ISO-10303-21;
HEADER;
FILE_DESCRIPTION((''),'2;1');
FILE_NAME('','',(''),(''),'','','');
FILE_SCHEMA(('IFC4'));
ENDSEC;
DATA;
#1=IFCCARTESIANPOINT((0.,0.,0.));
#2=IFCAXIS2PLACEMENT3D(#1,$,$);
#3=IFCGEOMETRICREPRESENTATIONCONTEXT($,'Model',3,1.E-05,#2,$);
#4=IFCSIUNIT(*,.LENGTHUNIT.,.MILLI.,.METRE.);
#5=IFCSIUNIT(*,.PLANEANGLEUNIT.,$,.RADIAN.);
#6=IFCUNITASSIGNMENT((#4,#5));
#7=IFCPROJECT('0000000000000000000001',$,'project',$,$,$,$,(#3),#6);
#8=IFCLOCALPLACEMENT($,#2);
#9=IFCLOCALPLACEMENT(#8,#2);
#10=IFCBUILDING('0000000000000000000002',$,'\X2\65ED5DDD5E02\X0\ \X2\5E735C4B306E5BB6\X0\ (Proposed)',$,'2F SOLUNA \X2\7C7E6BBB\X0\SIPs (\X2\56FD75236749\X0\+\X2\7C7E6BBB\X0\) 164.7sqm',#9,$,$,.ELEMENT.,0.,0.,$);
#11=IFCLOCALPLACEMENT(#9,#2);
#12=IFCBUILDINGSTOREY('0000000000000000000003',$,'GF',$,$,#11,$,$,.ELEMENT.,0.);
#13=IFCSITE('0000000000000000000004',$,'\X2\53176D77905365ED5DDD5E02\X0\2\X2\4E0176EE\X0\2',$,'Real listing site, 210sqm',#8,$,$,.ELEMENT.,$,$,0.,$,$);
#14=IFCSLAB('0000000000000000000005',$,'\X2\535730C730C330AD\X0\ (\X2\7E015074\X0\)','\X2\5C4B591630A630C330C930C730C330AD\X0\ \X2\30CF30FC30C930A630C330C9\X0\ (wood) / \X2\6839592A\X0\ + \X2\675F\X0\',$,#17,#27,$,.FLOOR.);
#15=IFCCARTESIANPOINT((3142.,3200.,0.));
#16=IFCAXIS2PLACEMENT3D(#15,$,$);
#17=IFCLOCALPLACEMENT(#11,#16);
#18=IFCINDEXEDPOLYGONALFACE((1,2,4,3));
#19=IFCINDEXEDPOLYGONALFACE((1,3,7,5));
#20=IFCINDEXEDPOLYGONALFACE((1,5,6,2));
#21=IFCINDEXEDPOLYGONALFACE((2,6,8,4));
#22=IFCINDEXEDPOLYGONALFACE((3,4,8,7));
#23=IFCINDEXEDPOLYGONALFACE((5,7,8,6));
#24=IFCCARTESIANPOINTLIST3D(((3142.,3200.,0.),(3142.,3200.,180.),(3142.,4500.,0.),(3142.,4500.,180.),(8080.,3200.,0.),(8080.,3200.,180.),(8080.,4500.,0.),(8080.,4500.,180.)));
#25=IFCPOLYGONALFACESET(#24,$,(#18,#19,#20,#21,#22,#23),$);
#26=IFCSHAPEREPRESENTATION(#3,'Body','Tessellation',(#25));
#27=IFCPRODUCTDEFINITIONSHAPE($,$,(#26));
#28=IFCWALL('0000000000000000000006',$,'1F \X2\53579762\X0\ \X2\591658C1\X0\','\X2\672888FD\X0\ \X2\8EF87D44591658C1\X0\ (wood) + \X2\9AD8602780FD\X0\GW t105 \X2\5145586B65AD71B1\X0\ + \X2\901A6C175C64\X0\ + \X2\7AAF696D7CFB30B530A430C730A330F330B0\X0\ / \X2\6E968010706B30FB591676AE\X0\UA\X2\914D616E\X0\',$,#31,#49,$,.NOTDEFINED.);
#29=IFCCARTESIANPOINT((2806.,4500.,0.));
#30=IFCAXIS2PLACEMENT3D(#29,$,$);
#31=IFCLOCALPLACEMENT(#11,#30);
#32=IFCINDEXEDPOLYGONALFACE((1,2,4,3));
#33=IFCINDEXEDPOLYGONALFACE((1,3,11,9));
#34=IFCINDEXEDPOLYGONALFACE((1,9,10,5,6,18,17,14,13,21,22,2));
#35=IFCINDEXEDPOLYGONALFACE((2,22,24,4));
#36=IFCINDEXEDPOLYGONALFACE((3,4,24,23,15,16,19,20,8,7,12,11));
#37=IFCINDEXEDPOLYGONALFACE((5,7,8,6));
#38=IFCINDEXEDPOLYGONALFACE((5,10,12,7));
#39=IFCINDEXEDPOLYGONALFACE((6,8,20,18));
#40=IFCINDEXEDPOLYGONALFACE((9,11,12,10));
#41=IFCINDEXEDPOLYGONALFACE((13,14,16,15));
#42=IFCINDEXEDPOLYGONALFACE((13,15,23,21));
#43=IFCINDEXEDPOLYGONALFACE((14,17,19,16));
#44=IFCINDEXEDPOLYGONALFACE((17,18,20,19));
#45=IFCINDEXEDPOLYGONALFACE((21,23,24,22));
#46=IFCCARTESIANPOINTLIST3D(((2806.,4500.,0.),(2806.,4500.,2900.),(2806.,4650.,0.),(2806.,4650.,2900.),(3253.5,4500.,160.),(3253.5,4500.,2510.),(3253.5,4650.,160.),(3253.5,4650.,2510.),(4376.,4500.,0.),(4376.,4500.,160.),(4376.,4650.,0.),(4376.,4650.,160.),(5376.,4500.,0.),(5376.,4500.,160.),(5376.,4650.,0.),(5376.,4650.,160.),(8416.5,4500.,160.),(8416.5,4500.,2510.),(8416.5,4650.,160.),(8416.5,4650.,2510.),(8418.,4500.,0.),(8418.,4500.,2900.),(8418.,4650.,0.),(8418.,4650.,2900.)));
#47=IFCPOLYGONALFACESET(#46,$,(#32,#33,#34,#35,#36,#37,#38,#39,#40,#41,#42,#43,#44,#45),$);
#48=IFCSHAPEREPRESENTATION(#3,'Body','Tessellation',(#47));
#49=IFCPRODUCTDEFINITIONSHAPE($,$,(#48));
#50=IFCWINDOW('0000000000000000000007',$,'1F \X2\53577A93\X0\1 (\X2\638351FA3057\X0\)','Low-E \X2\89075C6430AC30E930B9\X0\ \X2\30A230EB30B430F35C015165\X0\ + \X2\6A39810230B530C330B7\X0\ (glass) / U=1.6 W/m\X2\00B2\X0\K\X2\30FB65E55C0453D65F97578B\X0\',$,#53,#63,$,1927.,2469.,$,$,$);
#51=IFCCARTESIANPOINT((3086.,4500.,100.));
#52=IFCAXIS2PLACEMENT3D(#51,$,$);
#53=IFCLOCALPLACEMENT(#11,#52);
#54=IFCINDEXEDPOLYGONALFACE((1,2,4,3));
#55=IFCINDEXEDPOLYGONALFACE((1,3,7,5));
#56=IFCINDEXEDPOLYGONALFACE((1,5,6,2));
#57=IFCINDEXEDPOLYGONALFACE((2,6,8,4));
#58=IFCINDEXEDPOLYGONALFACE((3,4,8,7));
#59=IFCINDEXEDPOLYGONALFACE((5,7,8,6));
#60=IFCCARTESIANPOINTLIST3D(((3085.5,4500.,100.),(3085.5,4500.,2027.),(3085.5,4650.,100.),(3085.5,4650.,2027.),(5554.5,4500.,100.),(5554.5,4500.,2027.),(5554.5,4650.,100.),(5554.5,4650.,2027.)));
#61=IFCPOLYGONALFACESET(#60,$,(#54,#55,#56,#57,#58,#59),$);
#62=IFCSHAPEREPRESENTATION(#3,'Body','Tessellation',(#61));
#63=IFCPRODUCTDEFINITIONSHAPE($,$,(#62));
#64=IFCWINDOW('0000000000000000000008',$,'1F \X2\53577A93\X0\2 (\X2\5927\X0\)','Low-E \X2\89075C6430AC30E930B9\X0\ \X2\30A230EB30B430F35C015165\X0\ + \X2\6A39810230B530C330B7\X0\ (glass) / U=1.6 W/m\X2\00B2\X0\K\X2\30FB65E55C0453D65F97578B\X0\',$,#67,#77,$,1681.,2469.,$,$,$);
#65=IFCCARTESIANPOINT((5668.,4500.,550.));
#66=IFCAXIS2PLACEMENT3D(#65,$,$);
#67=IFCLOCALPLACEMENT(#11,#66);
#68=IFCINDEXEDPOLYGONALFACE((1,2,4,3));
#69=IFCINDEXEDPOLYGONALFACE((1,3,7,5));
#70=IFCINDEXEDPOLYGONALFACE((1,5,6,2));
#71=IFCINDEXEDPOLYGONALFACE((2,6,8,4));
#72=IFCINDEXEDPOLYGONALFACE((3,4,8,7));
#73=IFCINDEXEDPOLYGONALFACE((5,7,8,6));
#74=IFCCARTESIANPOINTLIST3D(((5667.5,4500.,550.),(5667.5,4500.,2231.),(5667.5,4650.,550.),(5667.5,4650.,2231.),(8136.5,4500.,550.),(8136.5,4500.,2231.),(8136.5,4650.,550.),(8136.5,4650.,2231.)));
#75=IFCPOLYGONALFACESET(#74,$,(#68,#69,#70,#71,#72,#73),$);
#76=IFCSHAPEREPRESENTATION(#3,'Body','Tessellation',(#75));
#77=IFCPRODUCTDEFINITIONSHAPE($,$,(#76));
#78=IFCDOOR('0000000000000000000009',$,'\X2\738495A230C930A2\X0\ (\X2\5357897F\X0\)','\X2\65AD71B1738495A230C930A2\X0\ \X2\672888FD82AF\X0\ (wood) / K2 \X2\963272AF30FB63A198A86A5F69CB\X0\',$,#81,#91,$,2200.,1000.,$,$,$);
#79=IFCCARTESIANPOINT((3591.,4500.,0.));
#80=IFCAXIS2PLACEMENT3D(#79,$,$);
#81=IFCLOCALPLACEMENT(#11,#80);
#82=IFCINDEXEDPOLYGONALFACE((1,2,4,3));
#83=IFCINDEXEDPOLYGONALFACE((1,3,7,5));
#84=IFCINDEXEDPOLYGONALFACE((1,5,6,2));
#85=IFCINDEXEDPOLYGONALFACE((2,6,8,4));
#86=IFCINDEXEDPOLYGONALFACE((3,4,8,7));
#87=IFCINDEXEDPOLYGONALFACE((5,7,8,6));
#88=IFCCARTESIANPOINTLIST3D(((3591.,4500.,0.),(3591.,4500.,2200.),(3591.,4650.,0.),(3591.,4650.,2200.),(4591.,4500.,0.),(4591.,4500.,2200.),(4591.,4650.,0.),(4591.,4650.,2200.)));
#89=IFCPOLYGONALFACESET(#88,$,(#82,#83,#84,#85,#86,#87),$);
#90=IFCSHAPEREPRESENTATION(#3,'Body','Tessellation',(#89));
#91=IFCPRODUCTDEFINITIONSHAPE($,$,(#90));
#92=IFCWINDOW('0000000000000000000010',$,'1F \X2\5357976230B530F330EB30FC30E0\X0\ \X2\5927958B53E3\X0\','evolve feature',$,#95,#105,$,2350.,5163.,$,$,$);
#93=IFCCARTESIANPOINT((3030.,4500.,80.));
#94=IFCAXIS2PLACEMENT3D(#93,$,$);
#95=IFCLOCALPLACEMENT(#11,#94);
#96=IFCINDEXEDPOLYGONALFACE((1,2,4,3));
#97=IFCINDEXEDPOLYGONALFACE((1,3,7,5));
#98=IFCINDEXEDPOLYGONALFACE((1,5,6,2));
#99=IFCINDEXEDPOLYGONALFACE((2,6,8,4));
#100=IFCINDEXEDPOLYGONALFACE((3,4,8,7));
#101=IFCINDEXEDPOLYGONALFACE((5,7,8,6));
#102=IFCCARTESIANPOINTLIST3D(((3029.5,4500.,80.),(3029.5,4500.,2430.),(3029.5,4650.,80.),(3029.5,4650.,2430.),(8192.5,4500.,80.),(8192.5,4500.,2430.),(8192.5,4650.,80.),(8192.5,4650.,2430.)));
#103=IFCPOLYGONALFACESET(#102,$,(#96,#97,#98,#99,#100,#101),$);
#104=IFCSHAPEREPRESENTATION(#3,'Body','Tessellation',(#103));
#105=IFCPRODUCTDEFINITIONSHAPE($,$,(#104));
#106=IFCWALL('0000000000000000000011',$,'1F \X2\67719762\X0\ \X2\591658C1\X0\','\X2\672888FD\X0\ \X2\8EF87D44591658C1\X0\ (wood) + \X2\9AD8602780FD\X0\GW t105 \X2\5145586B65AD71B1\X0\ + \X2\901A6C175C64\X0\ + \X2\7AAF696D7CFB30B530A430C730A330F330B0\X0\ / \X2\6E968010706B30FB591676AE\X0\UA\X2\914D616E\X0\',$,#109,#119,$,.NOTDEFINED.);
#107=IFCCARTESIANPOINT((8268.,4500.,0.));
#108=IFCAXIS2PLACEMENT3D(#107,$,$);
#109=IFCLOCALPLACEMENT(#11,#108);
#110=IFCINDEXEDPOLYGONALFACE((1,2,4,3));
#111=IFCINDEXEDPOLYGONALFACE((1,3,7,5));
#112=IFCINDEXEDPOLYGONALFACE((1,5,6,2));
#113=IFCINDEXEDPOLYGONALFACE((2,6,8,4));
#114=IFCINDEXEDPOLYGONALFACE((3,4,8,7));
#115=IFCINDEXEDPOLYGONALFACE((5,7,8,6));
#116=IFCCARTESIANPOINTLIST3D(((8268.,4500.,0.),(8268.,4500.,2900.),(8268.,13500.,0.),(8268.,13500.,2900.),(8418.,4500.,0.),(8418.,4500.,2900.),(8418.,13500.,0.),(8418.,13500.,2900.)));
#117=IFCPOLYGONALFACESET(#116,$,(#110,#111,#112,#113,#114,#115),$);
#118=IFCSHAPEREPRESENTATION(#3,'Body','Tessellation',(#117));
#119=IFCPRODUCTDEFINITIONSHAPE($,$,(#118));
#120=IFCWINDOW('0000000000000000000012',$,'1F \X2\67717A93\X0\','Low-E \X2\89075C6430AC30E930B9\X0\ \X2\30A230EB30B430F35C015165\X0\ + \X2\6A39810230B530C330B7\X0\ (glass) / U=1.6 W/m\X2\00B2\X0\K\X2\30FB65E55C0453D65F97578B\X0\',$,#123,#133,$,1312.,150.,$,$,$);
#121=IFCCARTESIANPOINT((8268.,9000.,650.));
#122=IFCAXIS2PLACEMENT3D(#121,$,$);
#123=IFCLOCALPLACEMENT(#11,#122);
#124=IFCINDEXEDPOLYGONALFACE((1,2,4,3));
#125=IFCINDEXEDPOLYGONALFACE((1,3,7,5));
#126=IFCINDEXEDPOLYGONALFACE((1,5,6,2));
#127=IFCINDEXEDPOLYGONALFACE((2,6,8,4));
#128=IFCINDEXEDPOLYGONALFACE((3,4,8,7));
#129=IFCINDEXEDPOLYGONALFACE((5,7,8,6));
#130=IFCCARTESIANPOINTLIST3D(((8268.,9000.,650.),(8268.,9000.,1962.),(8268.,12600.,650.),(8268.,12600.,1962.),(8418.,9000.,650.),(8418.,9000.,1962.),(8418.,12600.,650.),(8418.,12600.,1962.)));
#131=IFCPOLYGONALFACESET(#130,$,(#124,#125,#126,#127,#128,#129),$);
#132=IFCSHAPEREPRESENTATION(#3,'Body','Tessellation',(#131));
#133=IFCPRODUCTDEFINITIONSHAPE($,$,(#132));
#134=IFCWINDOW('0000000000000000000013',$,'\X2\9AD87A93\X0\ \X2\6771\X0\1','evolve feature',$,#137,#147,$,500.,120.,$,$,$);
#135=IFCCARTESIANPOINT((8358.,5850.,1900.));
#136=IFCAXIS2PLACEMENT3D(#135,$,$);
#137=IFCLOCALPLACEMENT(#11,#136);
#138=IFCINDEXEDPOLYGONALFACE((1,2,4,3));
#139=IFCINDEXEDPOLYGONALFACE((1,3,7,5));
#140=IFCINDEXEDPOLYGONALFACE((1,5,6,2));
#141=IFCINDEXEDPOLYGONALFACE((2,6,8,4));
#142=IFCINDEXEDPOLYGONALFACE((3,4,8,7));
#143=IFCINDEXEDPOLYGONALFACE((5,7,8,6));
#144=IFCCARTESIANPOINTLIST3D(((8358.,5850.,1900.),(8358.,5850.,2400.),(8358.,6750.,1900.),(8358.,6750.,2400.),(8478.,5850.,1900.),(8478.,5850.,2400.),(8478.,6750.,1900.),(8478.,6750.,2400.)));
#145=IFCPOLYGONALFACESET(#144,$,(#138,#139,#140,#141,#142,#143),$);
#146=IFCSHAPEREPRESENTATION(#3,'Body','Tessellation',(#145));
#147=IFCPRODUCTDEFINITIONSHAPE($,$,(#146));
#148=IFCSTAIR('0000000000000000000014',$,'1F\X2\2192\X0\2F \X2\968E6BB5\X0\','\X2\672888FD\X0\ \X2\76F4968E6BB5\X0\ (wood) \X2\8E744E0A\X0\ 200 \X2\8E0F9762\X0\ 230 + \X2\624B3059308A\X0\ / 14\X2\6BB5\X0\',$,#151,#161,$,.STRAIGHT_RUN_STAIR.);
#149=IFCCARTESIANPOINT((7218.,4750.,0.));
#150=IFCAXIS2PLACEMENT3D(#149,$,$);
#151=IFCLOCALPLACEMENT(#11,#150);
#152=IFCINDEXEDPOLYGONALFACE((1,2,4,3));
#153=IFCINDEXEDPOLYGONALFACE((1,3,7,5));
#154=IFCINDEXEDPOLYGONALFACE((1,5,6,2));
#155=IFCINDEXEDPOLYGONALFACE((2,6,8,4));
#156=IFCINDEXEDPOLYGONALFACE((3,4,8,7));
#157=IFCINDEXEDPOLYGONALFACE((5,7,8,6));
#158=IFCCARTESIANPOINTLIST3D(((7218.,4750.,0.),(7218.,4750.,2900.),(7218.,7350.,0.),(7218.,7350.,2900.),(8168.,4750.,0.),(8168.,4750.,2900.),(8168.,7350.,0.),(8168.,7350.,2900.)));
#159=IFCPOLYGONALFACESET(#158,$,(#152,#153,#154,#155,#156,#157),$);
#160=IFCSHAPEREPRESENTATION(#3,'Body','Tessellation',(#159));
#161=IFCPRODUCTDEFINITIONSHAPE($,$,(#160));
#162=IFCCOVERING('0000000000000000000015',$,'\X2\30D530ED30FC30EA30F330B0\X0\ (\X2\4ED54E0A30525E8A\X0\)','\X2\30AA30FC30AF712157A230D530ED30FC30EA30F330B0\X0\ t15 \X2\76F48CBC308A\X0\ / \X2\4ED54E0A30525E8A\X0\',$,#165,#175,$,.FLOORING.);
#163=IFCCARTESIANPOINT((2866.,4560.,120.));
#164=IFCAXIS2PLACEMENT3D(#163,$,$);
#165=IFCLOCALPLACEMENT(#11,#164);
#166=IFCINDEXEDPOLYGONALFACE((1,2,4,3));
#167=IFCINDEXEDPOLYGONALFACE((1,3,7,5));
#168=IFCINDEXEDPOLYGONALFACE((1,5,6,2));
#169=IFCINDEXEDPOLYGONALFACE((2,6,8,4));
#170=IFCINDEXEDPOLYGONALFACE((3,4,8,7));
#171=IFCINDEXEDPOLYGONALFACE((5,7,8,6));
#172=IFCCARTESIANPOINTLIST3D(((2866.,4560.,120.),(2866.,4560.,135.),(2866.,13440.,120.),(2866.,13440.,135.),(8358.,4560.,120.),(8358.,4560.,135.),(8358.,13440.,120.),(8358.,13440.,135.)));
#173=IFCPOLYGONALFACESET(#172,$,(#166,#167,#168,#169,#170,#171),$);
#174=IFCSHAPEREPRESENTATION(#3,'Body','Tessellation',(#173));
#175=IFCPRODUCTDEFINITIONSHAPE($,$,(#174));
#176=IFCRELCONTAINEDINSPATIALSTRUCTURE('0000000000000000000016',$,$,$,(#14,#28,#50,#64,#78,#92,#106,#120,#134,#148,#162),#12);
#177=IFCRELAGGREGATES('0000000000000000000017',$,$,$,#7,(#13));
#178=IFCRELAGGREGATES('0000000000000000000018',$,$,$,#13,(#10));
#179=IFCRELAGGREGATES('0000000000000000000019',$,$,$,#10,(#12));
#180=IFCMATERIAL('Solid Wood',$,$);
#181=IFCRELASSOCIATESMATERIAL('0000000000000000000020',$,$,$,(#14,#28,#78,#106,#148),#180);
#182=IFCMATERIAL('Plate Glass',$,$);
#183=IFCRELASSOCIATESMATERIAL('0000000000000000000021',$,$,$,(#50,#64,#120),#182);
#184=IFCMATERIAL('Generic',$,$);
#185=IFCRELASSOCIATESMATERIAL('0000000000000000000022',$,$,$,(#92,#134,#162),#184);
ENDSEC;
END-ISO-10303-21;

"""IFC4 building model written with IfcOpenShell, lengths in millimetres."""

from ifc_helpers import new_model, si_unit, frame, frame_2d, origin, place, context, project, spatial, rectangle, extrude, material, element, fill, save


model = new_model("IFC4")

# Units and contexts
model_context = context("Model", 3, precision=1e-05, world=origin())
ifc_project = project(units=[si_unit("LENGTHUNIT", "METRE", prefix="MILLI"), si_unit("PLANEANGLEUNIT", "RADIAN")], contexts=[model_context])

# Site, building, storey
site_placement = place(None, origin())
site = spatial("IfcSite", under=ifc_project, at=site_placement, Name="北海道旭川市2丁目2", ObjectType="Real listing site, 210sqm", CompositionType="ELEMENT", RefElevation=0.0)
building_placement = place(site_placement, origin())
building = spatial("IfcBuilding", under=site, at=building_placement, Name="旭川市 平屋の家 (Proposed)", ObjectType="2F SOLUNA 籾殻SIPs (国産杉+籾殻) 164.7sqm", CompositionType="ELEMENT", ElevationOfRefHeight=0.0, ElevationOfTerrain=0.0)
storey_placement = place(building_placement, origin())
storey = spatial("IfcBuildingStorey", under=building, at=storey_placement, Name="GF", CompositionType="ELEMENT", Elevation=0.0)

# Slab
ifc_material_1 = material(Name="Solid Wood")
slab_1_placement = place(storey_placement, frame((3142.0, 3200.0, 0.0)))
element("IfcSlab", 1, at=slab_1_placement, inside=storey, material=ifc_material_1, Name="南デッキ (縁側)", Description="屋外ウッドデッキ ハードウッド (wood) / 根太 + 束", PredefinedType="FLOOR", context=model_context, shape_type="SweptSolid", body=[
    extrude(rectangle(XDim=4938.0, YDim=1300.0, at=frame_2d((2469.0, 650.0))), frame((3142.0, 3200.0, 0.0)), (0.0, 0.0, 1.0), 180.0),
])
ifc_material_2 = material(Name="Generic")

# Wall, openings, windows, door
wall_1_placement = place(storey_placement, frame((2806.0, 4500.0, 0.0)))
wall_1 = element("IfcWall", 2, at=wall_1_placement, inside=storey, material=ifc_material_1, Name="1F 南面 外壁", Description="木製 軸組外壁 (wood) + 高性能GW t105 充填断熱 + 通気層 + 窯業系サイディング / 準耐火・外皮UA配慮", PredefinedType="NOTDEFINED", context=model_context, shape_type="SweptSolid", body=[
    extrude(rectangle(XDim=5612.0, YDim=150.0, at=frame_2d((2806.0, 75.0))), frame((2806.0, 4500.0, 0.0)), (0.0, 0.0, 1.0), 2900.0),
])
opening_1_placement = place(storey_placement, frame((3086.0, 4500.0, 100.0)))
opening_1 = element("IfcOpeningElement", 3, at=opening_1_placement, cuts=wall_1, PredefinedType="NOTDEFINED", context=model_context, shape_type="SweptSolid", body=[
    extrude(rectangle(XDim=2469.0, YDim=150.0, at=frame_2d((1234.0, 75.0))), frame((3086.0, 4500.0, 100.0)), (0.0, 0.0, 1.0), 1927.0),
])
opening_2_placement = place(storey_placement, frame((5668.0, 4500.0, 550.0)))
opening_2 = element("IfcOpeningElement", 4, at=opening_2_placement, cuts=wall_1, PredefinedType="NOTDEFINED", context=model_context, shape_type="SweptSolid", body=[
    extrude(rectangle(XDim=2469.0, YDim=150.0, at=frame_2d((1234.0, 75.0))), frame((5668.0, 4500.0, 550.0)), (0.0, 0.0, 1.0), 1681.0),
])
opening_3_placement = place(storey_placement, frame((3591.0, 4500.0, 0.0)))
opening_3 = element("IfcOpeningElement", 5, at=opening_3_placement, cuts=wall_1, PredefinedType="NOTDEFINED", context=model_context, shape_type="SweptSolid", body=[
    extrude(rectangle(XDim=1000.0, YDim=150.0, at=frame_2d((500.0, 75.0))), frame((3591.0, 4500.0, 0.0)), (0.0, 0.0, 1.0), 2200.0),
])
opening_4_placement = place(storey_placement, frame((3030.0, 4500.0, 80.0)))
opening_4 = element("IfcOpeningElement", 6, at=opening_4_placement, cuts=wall_1, PredefinedType="NOTDEFINED", context=model_context, shape_type="SweptSolid", body=[
    extrude(rectangle(XDim=5163.0, YDim=150.0, at=frame_2d((2581.0, 75.0))), frame((3030.0, 4500.0, 80.0)), (0.0, 0.0, 1.0), 2350.0),
])
ifc_material_3 = material(Name="Plate Glass")
window_1_placement = place(storey_placement, frame((3086.0, 4500.0, 100.0)))
window_1 = element("IfcWindow", 7, at=window_1_placement, inside=storey, material=ifc_material_3, Name="1F 南窓1 (掃出し)", Description="Low-E 複層ガラス アルゴン封入 + 樹脂サッシ (glass) / U=1.6 W/m²K・日射取得型", OverallHeight=1927.0, OverallWidth=2469.0, context=model_context, shape_type="SweptSolid", body=[
    extrude(rectangle(XDim=2469.0, YDim=150.0, at=frame_2d((1234.0, 75.0))), frame((3086.0, 4500.0, 100.0)), (0.0, 0.0, 1.0), 1927.0),
])
fill(opening_1, window_1)
window_2_placement = place(storey_placement, frame((5668.0, 4500.0, 550.0)))
window_2 = element("IfcWindow", 8, at=window_2_placement, inside=storey, material=ifc_material_3, Name="1F 南窓2 (大)", Description="Low-E 複層ガラス アルゴン封入 + 樹脂サッシ (glass) / U=1.6 W/m²K・日射取得型", OverallHeight=1681.0, OverallWidth=2469.0, context=model_context, shape_type="SweptSolid", body=[
    extrude(rectangle(XDim=2469.0, YDim=150.0, at=frame_2d((1234.0, 75.0))), frame((5668.0, 4500.0, 550.0)), (0.0, 0.0, 1.0), 1681.0),
])
fill(opening_2, window_2)
door_placement = place(storey_placement, frame((3591.0, 4500.0, 0.0)))
door = element("IfcDoor", 9, at=door_placement, inside=storey, material=ifc_material_1, Name="玄関ドア (南西)", Description="断熱玄関ドア 木製芯 (wood) / K2 防犯・採風機構", OverallHeight=2200.0, OverallWidth=1000.0, context=model_context, shape_type="SweptSolid", body=[
    extrude(rectangle(XDim=1000.0, YDim=150.0, at=frame_2d((500.0, 75.0))), frame((3591.0, 4500.0, 0.0)), (0.0, 0.0, 1.0), 2200.0),
])
fill(opening_3, door)
window_3_placement = place(storey_placement, frame((3030.0, 4500.0, 80.0)))
window_3 = element("IfcWindow", 10, at=window_3_placement, inside=storey, material=ifc_material_2, Name="1F 南面サンルーム 大開口", Description="evolve feature", OverallHeight=2350.0, OverallWidth=5163.0, context=model_context, shape_type="SweptSolid", body=[
    extrude(rectangle(XDim=5163.0, YDim=150.0, at=frame_2d((2581.0, 75.0))), frame((3030.0, 4500.0, 80.0)), (0.0, 0.0, 1.0), 2350.0),
])
fill(opening_4, window_3)

# Wall, openings, windows
wall_2_placement = place(storey_placement, frame((8268.0, 4500.0, 0.0)))
wall_2 = element("IfcWall", 11, at=wall_2_placement, inside=storey, material=ifc_material_1, Name="1F 東面 外壁", Description="木製 軸組外壁 (wood) + 高性能GW t105 充填断熱 + 通気層 + 窯業系サイディング / 準耐火・外皮UA配慮", PredefinedType="NOTDEFINED", context=model_context, shape_type="SweptSolid", body=[
    extrude(rectangle(XDim=150.0, YDim=9000.0, at=frame_2d((75.0, 4500.0))), frame((8268.0, 4500.0, 0.0)), (0.0, 0.0, 1.0), 2900.0),
])
opening_5_placement = place(storey_placement, frame((8268.0, 9000.0, 650.0)))
opening_5 = element("IfcOpeningElement", 12, at=opening_5_placement, cuts=wall_2, PredefinedType="NOTDEFINED", context=model_context, shape_type="SweptSolid", body=[
    extrude(rectangle(XDim=150.0, YDim=3600.0, at=frame_2d((75.0, 1800.0))), frame((8268.0, 9000.0, 650.0)), (0.0, 0.0, 1.0), 1312.0),
])
opening_6_placement = place(storey_placement, frame((8358.0, 5850.0, 1900.0)))
opening_6 = element("IfcOpeningElement", 13, at=opening_6_placement, cuts=wall_2, PredefinedType="NOTDEFINED", context=model_context, shape_type="SweptSolid", body=[
    extrude(rectangle(XDim=120.0, YDim=900.0, at=frame_2d((60.0, 450.0))), frame((8358.0, 5850.0, 1900.0)), (0.0, 0.0, 1.0), 500.0),
])
window_4_placement = place(storey_placement, frame((8268.0, 9000.0, 650.0)))
window_4 = element("IfcWindow", 14, at=window_4_placement, inside=storey, material=ifc_material_3, Name="1F 東窓", Description="Low-E 複層ガラス アルゴン封入 + 樹脂サッシ (glass) / U=1.6 W/m²K・日射取得型", OverallHeight=1312.0, OverallWidth=150.0, context=model_context, shape_type="SweptSolid", body=[
    extrude(rectangle(XDim=150.0, YDim=3600.0, at=frame_2d((75.0, 1800.0))), frame((8268.0, 9000.0, 650.0)), (0.0, 0.0, 1.0), 1312.0),
])
fill(opening_5, window_4)
window_5_placement = place(storey_placement, frame((8358.0, 5850.0, 1900.0)))
window_5 = element("IfcWindow", 15, at=window_5_placement, inside=storey, material=ifc_material_2, Name="高窓 東1", Description="evolve feature", OverallHeight=500.0, OverallWidth=120.0, context=model_context, shape_type="SweptSolid", body=[
    extrude(rectangle(XDim=120.0, YDim=900.0, at=frame_2d((60.0, 450.0))), frame((8358.0, 5850.0, 1900.0)), (0.0, 0.0, 1.0), 500.0),
])
fill(opening_6, window_5)

# Stair
stair_placement = place(storey_placement, frame((7218.0, 4750.0, 0.0)))
element("IfcStair", 16, at=stair_placement, inside=storey, material=ifc_material_1, Name="1F→2F 階段", Description="木製 直階段 (wood) 蹴上 200 踏面 230 + 手すり / 14段", PredefinedType="STRAIGHT_RUN_STAIR", context=model_context, shape_type="SweptSolid", body=[
    extrude(rectangle(XDim=950.0, YDim=2600.0, at=frame_2d((475.0, 1300.0))), frame((7218.0, 4750.0, 0.0)), (0.0, 0.0, 1.0), 2900.0),
])

# Covering
covering_placement = place(storey_placement, frame((2866.0, 4560.0, 120.0)))
element("IfcCovering", 17, at=covering_placement, inside=storey, material=ifc_material_2, Name="フローリング (仕上げ床)", Description="オーク無垢フローリング t15 直貼り / 仕上げ床", PredefinedType="FLOORING", context=model_context, shape_type="SweptSolid", body=[
    extrude(rectangle(XDim=5492.0, YDim=8880.0, at=frame_2d((2746.0, 4440.0))), frame((2866.0, 4560.0, 120.0)), (0.0, 0.0, 1.0), 15.0),
])

save(model, "model.ifc")
